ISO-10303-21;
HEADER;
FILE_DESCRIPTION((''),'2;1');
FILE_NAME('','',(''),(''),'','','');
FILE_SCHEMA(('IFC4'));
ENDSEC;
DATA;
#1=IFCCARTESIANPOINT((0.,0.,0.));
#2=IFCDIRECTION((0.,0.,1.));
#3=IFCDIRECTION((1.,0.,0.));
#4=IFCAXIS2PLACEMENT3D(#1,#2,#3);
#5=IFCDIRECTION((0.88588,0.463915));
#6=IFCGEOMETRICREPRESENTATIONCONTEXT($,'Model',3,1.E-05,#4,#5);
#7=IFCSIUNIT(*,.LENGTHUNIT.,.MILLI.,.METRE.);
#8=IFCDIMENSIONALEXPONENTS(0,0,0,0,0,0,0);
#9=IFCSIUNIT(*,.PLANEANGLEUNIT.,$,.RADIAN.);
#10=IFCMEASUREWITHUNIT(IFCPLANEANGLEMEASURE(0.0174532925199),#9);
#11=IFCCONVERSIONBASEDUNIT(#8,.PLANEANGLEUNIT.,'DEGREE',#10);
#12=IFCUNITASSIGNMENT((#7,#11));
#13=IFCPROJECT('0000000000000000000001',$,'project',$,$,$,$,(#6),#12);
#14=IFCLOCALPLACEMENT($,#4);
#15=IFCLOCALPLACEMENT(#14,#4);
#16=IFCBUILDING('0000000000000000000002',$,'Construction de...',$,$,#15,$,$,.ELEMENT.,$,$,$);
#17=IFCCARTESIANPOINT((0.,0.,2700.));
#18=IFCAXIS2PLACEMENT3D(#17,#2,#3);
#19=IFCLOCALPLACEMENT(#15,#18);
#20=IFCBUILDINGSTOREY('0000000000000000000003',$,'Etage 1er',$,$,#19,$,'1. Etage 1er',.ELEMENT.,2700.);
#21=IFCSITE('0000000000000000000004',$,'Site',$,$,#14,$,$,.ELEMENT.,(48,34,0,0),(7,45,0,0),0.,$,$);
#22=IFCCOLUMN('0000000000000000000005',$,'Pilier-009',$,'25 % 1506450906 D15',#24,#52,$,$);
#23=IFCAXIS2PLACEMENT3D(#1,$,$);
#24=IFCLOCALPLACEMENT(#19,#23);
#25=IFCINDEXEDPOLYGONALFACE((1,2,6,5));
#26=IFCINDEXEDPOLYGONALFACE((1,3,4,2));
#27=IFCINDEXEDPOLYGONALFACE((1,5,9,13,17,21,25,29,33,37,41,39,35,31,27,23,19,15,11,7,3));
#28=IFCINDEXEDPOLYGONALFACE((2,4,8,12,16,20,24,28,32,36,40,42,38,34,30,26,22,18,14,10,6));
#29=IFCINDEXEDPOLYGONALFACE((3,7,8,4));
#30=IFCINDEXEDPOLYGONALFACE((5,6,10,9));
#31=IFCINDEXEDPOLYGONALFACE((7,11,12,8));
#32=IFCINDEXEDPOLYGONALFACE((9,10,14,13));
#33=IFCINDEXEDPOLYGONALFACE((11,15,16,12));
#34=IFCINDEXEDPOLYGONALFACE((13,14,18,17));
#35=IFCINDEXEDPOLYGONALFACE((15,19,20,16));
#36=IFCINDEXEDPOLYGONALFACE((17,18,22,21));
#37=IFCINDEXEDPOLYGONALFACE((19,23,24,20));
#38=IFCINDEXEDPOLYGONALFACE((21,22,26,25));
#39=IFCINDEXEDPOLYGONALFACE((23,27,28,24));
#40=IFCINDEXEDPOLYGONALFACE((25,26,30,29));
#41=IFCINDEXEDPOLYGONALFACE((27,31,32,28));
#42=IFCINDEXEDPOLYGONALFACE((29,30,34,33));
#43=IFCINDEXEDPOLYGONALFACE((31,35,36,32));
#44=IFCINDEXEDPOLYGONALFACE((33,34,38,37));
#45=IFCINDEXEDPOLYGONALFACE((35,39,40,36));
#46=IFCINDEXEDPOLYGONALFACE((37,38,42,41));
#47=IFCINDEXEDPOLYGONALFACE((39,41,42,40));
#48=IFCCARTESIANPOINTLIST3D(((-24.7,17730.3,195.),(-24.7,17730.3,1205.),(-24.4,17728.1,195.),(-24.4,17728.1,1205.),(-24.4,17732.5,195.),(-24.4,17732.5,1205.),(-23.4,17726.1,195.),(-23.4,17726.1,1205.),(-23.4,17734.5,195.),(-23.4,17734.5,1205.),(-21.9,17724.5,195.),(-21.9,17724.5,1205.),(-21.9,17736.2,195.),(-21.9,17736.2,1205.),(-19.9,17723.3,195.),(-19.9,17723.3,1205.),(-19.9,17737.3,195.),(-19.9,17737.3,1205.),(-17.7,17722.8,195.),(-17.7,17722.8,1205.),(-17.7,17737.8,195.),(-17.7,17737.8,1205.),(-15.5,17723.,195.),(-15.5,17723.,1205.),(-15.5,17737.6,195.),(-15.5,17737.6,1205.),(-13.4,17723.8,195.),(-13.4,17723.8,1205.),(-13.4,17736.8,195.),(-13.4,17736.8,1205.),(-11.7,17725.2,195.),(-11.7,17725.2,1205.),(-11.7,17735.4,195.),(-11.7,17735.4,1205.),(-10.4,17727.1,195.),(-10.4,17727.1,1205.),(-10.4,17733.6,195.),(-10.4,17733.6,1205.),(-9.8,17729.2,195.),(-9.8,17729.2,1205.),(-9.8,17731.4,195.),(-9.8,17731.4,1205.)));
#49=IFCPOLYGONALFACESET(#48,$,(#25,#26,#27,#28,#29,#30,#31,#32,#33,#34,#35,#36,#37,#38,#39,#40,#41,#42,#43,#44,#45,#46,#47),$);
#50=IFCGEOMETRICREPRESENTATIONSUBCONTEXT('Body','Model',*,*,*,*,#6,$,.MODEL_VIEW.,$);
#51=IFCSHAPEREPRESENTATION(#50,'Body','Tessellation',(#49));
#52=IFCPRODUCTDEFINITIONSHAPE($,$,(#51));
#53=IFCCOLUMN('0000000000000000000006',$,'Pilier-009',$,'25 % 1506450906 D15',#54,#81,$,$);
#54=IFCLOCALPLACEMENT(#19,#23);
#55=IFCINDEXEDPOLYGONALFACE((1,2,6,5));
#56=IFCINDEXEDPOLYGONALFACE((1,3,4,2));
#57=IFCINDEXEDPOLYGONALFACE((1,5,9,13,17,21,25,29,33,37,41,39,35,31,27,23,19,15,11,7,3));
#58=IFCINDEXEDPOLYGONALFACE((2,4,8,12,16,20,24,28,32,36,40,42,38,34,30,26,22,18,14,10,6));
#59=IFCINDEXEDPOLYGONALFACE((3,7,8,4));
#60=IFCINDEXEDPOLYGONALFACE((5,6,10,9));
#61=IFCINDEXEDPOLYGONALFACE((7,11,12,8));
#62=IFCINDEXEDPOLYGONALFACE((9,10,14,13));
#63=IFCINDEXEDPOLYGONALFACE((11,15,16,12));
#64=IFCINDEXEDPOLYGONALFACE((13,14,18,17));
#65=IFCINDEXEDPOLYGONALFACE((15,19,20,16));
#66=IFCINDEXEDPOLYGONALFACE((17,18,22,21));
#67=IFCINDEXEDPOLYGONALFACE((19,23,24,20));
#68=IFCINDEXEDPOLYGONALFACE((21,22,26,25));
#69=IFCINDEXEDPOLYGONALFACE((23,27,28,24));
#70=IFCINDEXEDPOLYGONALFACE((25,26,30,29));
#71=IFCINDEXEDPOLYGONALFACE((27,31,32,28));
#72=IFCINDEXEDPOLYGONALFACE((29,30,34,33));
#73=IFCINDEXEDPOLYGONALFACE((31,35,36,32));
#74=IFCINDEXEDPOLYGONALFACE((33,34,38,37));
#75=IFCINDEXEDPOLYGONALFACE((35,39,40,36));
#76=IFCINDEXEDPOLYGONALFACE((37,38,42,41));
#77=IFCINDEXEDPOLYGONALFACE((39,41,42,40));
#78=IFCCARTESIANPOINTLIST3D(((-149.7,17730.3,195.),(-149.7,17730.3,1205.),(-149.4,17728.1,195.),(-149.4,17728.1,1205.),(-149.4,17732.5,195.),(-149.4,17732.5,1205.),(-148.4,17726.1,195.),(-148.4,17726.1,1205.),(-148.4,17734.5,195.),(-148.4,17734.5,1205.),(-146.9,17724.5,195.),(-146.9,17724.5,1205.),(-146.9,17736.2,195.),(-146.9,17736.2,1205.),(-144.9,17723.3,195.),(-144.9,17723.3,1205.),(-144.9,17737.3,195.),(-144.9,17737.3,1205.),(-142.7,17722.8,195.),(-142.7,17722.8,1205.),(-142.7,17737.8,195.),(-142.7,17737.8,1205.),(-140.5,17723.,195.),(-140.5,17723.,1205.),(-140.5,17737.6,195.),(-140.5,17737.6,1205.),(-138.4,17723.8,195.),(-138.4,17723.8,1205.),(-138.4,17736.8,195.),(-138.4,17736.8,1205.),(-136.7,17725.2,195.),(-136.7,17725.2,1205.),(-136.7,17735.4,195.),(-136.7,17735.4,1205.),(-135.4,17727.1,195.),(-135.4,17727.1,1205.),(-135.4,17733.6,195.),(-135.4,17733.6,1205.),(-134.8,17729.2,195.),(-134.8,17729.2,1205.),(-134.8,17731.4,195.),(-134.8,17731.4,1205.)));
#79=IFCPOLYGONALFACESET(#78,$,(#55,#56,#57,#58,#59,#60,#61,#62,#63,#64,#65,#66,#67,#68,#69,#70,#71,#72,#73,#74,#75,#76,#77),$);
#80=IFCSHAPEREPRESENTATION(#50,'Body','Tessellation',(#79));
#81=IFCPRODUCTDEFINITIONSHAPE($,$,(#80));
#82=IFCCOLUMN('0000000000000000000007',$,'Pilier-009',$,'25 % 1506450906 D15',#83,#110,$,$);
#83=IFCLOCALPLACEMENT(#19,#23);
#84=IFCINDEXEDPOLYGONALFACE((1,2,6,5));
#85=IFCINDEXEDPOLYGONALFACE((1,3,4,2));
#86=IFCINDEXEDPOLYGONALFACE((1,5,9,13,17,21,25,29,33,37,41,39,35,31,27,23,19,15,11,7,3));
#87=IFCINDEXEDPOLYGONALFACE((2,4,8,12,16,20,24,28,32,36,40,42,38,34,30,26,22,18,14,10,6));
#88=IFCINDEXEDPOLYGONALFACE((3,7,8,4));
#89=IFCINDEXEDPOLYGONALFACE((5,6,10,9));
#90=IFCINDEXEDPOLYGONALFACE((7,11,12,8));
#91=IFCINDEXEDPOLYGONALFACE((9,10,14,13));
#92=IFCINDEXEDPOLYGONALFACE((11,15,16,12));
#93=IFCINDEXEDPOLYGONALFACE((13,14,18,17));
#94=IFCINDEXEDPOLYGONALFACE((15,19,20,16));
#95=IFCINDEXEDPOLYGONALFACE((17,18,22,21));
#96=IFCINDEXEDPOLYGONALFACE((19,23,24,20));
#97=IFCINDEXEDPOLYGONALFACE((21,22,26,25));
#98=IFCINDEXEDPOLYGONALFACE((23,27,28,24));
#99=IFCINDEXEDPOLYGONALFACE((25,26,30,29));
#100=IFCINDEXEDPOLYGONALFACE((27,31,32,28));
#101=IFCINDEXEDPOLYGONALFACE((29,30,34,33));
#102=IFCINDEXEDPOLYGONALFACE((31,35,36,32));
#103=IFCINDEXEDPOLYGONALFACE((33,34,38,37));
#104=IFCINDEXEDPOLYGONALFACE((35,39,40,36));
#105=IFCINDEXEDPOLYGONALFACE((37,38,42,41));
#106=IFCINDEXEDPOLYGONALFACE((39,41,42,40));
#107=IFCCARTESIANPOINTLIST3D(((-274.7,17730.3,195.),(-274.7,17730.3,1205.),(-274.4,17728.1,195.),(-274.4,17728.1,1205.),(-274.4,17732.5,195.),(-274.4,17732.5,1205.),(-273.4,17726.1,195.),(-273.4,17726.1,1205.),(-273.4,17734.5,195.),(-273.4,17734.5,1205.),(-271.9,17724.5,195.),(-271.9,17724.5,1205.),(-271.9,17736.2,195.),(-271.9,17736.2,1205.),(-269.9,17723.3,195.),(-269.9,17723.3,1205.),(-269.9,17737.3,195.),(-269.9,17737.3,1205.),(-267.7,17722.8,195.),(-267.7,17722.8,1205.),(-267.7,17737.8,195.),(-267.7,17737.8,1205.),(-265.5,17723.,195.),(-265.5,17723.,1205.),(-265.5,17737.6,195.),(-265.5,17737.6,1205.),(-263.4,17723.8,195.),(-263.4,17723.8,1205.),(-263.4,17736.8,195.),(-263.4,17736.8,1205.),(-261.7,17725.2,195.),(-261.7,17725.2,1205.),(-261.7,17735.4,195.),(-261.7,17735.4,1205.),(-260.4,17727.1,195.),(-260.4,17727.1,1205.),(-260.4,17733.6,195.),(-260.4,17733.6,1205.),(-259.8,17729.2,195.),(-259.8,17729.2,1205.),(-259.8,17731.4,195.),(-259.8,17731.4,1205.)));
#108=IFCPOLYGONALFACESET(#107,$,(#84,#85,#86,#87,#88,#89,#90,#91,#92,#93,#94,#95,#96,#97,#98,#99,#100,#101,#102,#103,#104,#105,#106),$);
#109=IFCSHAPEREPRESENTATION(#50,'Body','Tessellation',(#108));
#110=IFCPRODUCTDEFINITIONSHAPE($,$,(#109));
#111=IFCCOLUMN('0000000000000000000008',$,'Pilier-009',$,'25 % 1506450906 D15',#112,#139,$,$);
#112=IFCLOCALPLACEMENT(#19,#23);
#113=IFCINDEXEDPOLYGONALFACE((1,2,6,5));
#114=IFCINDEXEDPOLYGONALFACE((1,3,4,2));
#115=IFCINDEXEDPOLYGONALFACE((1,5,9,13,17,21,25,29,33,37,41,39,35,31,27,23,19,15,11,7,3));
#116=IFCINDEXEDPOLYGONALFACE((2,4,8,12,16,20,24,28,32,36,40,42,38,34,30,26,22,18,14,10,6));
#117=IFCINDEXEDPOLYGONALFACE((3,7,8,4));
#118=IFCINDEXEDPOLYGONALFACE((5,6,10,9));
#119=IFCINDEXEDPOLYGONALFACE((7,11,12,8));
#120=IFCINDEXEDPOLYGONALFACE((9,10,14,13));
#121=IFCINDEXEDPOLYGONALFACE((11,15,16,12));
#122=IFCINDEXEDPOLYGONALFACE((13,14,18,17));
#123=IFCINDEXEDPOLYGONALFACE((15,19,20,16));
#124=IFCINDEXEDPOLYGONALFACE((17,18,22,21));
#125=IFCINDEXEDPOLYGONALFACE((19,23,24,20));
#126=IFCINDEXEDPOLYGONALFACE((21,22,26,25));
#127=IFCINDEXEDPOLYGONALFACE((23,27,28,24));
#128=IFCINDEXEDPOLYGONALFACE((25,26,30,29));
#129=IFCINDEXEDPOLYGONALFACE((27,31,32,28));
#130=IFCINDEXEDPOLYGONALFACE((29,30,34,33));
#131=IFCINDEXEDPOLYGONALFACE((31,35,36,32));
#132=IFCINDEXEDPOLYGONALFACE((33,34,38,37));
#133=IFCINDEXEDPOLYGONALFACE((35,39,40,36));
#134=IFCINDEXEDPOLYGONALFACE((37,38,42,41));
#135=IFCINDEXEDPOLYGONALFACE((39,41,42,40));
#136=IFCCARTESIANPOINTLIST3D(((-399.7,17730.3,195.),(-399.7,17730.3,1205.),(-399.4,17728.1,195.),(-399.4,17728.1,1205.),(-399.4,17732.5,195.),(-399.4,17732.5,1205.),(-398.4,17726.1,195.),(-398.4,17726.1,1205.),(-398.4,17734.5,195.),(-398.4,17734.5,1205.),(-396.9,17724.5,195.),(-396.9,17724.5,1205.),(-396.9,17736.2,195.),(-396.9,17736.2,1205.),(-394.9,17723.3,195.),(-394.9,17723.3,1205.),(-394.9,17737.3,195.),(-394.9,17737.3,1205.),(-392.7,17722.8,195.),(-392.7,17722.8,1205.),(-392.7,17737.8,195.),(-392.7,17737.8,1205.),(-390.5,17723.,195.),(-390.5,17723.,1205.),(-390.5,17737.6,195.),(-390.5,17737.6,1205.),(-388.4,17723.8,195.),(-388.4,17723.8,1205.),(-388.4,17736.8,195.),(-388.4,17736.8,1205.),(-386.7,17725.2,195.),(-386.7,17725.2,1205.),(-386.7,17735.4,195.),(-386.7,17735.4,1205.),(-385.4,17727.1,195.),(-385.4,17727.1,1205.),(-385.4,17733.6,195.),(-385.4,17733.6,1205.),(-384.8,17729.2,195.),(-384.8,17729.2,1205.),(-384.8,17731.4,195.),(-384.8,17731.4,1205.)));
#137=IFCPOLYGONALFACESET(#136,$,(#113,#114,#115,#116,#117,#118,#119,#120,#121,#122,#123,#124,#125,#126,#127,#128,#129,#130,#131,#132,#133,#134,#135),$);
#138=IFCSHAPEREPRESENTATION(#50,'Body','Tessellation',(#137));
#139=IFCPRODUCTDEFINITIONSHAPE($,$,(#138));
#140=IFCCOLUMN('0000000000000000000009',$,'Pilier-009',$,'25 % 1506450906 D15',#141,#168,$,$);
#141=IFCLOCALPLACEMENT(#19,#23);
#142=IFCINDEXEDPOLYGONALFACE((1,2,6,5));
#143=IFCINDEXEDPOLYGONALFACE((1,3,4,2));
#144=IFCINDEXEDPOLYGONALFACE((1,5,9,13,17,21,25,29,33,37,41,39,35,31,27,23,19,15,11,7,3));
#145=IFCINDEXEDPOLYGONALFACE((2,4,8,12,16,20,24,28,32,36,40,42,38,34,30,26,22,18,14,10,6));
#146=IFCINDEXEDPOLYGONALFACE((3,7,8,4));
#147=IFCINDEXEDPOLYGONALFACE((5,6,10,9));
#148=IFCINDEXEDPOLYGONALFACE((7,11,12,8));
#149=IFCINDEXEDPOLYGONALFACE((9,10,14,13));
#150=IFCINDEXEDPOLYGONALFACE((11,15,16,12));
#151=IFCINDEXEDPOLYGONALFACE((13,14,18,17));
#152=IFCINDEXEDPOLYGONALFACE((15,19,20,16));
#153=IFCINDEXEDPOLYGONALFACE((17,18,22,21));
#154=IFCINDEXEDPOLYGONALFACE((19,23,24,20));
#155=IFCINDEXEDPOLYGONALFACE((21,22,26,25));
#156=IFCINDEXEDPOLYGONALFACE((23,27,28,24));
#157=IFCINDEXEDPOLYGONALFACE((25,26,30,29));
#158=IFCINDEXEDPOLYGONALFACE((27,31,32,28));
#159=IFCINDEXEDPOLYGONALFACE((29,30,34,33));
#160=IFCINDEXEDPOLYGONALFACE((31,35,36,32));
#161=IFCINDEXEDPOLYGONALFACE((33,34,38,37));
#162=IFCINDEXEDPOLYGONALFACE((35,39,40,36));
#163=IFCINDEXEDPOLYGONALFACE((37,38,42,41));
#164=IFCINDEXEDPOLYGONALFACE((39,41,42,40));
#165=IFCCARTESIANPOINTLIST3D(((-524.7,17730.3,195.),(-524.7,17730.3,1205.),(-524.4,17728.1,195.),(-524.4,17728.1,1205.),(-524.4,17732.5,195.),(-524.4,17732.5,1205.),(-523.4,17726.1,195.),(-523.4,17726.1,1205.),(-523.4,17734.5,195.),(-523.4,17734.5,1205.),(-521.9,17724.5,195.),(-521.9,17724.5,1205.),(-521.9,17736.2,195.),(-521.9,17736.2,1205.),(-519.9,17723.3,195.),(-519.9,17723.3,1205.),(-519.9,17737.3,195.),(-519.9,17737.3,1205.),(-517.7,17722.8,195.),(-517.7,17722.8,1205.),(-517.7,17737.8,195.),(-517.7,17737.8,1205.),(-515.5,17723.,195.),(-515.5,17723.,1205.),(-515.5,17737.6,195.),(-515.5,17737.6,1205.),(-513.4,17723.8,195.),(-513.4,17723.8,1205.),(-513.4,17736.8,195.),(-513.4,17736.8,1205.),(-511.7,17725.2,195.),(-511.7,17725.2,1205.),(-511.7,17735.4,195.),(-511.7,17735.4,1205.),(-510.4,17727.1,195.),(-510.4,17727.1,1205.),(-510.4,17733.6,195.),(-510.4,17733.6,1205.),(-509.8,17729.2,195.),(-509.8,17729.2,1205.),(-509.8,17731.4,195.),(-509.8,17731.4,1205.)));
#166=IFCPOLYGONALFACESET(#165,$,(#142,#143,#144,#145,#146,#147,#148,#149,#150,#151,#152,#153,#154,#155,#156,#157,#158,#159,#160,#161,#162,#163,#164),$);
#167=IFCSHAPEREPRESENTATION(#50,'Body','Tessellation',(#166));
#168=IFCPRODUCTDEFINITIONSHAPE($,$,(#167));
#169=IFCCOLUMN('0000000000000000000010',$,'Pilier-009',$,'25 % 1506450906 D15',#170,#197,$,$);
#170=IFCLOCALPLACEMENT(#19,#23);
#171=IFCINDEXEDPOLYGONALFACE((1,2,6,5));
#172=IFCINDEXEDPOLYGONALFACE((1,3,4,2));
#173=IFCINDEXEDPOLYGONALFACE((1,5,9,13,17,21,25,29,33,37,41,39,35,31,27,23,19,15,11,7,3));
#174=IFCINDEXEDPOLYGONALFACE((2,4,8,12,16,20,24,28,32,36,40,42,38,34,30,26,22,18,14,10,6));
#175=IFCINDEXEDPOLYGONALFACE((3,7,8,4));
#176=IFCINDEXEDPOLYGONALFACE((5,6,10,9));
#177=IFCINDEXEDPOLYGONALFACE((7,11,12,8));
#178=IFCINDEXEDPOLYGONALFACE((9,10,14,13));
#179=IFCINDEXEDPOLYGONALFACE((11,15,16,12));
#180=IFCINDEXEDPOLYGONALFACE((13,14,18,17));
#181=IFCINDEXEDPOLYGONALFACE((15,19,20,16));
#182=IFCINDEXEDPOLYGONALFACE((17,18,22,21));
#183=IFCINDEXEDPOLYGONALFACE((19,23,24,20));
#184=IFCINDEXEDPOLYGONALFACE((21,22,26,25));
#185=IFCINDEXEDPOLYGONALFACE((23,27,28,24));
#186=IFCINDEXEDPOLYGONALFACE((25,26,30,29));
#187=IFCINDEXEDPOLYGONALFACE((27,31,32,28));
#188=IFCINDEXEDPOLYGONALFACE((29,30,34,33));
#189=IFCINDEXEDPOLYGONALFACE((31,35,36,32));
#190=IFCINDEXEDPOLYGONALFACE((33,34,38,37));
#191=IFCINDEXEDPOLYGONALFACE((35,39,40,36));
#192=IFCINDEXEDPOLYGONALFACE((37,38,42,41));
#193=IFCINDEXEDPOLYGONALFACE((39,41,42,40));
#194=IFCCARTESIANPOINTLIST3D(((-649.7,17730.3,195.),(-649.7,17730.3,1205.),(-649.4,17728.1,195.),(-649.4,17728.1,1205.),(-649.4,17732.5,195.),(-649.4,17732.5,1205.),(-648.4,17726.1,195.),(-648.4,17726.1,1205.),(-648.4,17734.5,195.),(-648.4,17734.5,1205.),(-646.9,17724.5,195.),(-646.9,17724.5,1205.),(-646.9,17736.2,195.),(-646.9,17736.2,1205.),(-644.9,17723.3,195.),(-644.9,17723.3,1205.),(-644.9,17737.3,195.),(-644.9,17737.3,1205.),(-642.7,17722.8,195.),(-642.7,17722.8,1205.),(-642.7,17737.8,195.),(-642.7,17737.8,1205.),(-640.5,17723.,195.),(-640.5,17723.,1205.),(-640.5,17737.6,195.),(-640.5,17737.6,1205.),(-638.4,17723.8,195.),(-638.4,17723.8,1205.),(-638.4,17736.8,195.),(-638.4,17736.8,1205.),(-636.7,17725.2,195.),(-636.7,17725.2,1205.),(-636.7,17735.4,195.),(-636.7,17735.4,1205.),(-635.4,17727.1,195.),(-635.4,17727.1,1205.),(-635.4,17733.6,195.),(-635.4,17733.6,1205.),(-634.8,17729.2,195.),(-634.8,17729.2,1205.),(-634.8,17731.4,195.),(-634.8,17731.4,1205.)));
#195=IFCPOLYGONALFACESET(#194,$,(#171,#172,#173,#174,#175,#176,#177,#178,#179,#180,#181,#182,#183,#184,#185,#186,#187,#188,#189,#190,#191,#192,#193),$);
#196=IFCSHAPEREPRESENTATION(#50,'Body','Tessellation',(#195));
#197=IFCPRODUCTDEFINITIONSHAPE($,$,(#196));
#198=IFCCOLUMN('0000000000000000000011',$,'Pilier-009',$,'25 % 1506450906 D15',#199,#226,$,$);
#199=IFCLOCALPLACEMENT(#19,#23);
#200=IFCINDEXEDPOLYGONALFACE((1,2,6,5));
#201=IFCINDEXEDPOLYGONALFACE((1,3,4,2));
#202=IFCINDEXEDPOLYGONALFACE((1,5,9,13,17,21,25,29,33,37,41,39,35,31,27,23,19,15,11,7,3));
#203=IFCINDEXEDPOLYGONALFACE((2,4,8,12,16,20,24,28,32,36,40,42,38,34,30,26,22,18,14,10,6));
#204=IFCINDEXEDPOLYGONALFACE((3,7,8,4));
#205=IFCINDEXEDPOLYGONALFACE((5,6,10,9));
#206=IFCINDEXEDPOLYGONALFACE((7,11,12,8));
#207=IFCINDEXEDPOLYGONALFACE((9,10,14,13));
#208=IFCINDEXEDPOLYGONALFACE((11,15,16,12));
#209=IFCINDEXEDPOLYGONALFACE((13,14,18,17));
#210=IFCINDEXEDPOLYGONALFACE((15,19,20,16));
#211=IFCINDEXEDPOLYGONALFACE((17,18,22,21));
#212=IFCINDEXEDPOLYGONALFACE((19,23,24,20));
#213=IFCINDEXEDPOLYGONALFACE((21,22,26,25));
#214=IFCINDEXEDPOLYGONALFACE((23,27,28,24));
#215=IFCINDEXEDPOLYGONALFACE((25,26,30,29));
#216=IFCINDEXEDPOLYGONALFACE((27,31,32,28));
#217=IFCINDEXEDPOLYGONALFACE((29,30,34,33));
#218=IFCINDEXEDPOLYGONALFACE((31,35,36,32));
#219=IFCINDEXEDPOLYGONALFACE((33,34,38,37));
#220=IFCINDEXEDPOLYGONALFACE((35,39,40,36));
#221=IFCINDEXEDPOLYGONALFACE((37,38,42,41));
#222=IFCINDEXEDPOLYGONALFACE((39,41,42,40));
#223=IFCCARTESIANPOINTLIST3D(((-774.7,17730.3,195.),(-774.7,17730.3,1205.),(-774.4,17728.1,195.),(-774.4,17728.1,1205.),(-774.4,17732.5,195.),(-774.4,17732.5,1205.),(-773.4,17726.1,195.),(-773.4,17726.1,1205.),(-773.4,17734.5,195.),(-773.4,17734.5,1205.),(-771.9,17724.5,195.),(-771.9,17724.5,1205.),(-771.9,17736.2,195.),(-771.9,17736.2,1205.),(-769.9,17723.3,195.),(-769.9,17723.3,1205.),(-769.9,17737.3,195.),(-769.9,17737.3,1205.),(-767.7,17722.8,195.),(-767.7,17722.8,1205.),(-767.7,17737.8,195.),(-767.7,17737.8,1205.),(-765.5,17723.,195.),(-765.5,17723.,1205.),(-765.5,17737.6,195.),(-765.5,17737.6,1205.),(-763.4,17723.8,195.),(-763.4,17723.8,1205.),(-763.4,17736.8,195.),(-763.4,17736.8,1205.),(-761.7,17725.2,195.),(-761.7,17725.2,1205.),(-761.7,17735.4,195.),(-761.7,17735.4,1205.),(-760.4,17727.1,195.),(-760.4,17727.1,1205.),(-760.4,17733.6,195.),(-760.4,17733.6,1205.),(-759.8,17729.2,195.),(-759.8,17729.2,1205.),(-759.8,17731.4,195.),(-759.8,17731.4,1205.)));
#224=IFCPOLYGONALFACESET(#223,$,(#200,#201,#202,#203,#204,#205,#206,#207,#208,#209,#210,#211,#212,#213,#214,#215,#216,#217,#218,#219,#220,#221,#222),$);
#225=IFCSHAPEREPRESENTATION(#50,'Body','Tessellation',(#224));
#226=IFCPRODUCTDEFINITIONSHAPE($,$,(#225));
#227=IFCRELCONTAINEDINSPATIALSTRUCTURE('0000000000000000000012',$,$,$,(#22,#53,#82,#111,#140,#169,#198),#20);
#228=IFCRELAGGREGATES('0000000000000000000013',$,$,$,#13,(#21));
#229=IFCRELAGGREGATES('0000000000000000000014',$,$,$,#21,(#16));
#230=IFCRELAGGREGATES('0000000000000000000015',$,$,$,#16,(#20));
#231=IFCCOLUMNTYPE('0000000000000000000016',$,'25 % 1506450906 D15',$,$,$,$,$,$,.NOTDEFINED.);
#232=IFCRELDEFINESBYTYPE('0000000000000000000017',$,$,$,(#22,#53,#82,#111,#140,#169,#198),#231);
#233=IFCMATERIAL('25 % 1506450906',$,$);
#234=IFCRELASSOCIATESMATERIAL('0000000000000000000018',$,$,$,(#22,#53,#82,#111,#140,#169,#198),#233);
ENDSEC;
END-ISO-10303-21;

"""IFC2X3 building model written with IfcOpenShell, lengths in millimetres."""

from ifc_helpers import new_model, entity, si_unit, converted_unit, direction, frame, origin_with_axes, origin_2d_with_axis, place, context, subcontext, project, spatial, circle, extrude, material, type_object, element, save


model = new_model("IFC2X3")

# Units and contexts
model_context = context("Model", 3, precision=1e-05, world=origin_with_axes(), true_north=direction((0.88588, 0.463915)))
body_context = subcontext(model_context, "Body", "Model", "MODEL_VIEW")
ifc_project = project(units=[si_unit("LENGTHUNIT", "METRE", prefix="MILLI"), converted_unit("PLANEANGLEUNIT", "DEGREE", entity("IfcPlaneAngleMeasure", 0.0174532925199), si_unit("PLANEANGLEUNIT", "RADIAN"), dimensions=[0, 0, 0, 0, 0, 0, 0])], contexts=[model_context])

# Site, building, storey
site_placement = place(None, origin_with_axes())
site = spatial("IfcSite", under=ifc_project, at=site_placement, Name="Site", CompositionType="ELEMENT", RefLatitude=(48, 34, 0, 0), RefLongitude=(7, 45, 0, 0), RefElevation=0.0)
building_placement = place(site_placement, origin_with_axes())
building = spatial("IfcBuilding", under=site, at=building_placement, Name="Construction de...", CompositionType="ELEMENT")
storey_placement = place(building_placement, frame((0.0, 0.0, 2700.0), z_axis=(0.0, 0.0, 1.0), x_axis=(1.0, 0.0, 0.0)))
storey = spatial("IfcBuildingStorey", under=building, at=storey_placement, Name="Etage 1er", LongName="1. Etage 1er", CompositionType="ELEMENT", Elevation=2700.0)

# Columns
ifc_material_1 = material(Name="25 % 1506450906")
column_type_1 = type_object("IfcColumnType", Name="25 % 1506450906 D15", PredefinedType="NOTDEFINED")
for number, where, z_axis, x_axis, name in (
    (1, (-17.2, 17730.3, 195.0), (0.0, 0.0, 1.0), (-1.0, 0.0, 0.0), "Pilier-009"),
    (2, (-142.2, 17730.3, 195.0), (0.0, 0.0, 1.0), (-1.0, 0.0, 0.0), "Pilier-009"),
    (3, (-267.2, 17730.3, 195.0), (0.0, 0.0, 1.0), (-1.0, 0.0, 0.0), "Pilier-009"),
    (4, (-392.2, 17730.3, 195.0), (0.0, 0.0, 1.0), (-1.0, 0.0, 0.0), "Pilier-009"),
    (5, (-517.2, 17730.3, 195.0), (0.0, 0.0, 1.0), (-1.0, 0.0, 0.0), "Pilier-009"),
    (6, (-642.2, 17730.3, 195.0), (0.0, 0.0, 1.0), (-1.0, 0.0, 0.0), "Pilier-009"),
    (7, (-767.2, 17730.3, 195.0), (0.0, 0.0, 1.0), (-1.0, 0.0, 0.0), "Pilier-009"),
):
    element("IfcColumn", number, at=place(storey_placement, frame(where, z_axis=z_axis, x_axis=x_axis)), inside=storey, type_object=column_type_1, material=ifc_material_1, Name=name, ObjectType="25 % 1506450906 D15", context=body_context, shape_type="SweptSolid", body=[
        extrude(circle(Radius=7.5, at=origin_2d_with_axis()), origin_with_axes(), (0.0, 0.0, 1.0), 1010.0),
    ])

save(model, "model.ifc")
